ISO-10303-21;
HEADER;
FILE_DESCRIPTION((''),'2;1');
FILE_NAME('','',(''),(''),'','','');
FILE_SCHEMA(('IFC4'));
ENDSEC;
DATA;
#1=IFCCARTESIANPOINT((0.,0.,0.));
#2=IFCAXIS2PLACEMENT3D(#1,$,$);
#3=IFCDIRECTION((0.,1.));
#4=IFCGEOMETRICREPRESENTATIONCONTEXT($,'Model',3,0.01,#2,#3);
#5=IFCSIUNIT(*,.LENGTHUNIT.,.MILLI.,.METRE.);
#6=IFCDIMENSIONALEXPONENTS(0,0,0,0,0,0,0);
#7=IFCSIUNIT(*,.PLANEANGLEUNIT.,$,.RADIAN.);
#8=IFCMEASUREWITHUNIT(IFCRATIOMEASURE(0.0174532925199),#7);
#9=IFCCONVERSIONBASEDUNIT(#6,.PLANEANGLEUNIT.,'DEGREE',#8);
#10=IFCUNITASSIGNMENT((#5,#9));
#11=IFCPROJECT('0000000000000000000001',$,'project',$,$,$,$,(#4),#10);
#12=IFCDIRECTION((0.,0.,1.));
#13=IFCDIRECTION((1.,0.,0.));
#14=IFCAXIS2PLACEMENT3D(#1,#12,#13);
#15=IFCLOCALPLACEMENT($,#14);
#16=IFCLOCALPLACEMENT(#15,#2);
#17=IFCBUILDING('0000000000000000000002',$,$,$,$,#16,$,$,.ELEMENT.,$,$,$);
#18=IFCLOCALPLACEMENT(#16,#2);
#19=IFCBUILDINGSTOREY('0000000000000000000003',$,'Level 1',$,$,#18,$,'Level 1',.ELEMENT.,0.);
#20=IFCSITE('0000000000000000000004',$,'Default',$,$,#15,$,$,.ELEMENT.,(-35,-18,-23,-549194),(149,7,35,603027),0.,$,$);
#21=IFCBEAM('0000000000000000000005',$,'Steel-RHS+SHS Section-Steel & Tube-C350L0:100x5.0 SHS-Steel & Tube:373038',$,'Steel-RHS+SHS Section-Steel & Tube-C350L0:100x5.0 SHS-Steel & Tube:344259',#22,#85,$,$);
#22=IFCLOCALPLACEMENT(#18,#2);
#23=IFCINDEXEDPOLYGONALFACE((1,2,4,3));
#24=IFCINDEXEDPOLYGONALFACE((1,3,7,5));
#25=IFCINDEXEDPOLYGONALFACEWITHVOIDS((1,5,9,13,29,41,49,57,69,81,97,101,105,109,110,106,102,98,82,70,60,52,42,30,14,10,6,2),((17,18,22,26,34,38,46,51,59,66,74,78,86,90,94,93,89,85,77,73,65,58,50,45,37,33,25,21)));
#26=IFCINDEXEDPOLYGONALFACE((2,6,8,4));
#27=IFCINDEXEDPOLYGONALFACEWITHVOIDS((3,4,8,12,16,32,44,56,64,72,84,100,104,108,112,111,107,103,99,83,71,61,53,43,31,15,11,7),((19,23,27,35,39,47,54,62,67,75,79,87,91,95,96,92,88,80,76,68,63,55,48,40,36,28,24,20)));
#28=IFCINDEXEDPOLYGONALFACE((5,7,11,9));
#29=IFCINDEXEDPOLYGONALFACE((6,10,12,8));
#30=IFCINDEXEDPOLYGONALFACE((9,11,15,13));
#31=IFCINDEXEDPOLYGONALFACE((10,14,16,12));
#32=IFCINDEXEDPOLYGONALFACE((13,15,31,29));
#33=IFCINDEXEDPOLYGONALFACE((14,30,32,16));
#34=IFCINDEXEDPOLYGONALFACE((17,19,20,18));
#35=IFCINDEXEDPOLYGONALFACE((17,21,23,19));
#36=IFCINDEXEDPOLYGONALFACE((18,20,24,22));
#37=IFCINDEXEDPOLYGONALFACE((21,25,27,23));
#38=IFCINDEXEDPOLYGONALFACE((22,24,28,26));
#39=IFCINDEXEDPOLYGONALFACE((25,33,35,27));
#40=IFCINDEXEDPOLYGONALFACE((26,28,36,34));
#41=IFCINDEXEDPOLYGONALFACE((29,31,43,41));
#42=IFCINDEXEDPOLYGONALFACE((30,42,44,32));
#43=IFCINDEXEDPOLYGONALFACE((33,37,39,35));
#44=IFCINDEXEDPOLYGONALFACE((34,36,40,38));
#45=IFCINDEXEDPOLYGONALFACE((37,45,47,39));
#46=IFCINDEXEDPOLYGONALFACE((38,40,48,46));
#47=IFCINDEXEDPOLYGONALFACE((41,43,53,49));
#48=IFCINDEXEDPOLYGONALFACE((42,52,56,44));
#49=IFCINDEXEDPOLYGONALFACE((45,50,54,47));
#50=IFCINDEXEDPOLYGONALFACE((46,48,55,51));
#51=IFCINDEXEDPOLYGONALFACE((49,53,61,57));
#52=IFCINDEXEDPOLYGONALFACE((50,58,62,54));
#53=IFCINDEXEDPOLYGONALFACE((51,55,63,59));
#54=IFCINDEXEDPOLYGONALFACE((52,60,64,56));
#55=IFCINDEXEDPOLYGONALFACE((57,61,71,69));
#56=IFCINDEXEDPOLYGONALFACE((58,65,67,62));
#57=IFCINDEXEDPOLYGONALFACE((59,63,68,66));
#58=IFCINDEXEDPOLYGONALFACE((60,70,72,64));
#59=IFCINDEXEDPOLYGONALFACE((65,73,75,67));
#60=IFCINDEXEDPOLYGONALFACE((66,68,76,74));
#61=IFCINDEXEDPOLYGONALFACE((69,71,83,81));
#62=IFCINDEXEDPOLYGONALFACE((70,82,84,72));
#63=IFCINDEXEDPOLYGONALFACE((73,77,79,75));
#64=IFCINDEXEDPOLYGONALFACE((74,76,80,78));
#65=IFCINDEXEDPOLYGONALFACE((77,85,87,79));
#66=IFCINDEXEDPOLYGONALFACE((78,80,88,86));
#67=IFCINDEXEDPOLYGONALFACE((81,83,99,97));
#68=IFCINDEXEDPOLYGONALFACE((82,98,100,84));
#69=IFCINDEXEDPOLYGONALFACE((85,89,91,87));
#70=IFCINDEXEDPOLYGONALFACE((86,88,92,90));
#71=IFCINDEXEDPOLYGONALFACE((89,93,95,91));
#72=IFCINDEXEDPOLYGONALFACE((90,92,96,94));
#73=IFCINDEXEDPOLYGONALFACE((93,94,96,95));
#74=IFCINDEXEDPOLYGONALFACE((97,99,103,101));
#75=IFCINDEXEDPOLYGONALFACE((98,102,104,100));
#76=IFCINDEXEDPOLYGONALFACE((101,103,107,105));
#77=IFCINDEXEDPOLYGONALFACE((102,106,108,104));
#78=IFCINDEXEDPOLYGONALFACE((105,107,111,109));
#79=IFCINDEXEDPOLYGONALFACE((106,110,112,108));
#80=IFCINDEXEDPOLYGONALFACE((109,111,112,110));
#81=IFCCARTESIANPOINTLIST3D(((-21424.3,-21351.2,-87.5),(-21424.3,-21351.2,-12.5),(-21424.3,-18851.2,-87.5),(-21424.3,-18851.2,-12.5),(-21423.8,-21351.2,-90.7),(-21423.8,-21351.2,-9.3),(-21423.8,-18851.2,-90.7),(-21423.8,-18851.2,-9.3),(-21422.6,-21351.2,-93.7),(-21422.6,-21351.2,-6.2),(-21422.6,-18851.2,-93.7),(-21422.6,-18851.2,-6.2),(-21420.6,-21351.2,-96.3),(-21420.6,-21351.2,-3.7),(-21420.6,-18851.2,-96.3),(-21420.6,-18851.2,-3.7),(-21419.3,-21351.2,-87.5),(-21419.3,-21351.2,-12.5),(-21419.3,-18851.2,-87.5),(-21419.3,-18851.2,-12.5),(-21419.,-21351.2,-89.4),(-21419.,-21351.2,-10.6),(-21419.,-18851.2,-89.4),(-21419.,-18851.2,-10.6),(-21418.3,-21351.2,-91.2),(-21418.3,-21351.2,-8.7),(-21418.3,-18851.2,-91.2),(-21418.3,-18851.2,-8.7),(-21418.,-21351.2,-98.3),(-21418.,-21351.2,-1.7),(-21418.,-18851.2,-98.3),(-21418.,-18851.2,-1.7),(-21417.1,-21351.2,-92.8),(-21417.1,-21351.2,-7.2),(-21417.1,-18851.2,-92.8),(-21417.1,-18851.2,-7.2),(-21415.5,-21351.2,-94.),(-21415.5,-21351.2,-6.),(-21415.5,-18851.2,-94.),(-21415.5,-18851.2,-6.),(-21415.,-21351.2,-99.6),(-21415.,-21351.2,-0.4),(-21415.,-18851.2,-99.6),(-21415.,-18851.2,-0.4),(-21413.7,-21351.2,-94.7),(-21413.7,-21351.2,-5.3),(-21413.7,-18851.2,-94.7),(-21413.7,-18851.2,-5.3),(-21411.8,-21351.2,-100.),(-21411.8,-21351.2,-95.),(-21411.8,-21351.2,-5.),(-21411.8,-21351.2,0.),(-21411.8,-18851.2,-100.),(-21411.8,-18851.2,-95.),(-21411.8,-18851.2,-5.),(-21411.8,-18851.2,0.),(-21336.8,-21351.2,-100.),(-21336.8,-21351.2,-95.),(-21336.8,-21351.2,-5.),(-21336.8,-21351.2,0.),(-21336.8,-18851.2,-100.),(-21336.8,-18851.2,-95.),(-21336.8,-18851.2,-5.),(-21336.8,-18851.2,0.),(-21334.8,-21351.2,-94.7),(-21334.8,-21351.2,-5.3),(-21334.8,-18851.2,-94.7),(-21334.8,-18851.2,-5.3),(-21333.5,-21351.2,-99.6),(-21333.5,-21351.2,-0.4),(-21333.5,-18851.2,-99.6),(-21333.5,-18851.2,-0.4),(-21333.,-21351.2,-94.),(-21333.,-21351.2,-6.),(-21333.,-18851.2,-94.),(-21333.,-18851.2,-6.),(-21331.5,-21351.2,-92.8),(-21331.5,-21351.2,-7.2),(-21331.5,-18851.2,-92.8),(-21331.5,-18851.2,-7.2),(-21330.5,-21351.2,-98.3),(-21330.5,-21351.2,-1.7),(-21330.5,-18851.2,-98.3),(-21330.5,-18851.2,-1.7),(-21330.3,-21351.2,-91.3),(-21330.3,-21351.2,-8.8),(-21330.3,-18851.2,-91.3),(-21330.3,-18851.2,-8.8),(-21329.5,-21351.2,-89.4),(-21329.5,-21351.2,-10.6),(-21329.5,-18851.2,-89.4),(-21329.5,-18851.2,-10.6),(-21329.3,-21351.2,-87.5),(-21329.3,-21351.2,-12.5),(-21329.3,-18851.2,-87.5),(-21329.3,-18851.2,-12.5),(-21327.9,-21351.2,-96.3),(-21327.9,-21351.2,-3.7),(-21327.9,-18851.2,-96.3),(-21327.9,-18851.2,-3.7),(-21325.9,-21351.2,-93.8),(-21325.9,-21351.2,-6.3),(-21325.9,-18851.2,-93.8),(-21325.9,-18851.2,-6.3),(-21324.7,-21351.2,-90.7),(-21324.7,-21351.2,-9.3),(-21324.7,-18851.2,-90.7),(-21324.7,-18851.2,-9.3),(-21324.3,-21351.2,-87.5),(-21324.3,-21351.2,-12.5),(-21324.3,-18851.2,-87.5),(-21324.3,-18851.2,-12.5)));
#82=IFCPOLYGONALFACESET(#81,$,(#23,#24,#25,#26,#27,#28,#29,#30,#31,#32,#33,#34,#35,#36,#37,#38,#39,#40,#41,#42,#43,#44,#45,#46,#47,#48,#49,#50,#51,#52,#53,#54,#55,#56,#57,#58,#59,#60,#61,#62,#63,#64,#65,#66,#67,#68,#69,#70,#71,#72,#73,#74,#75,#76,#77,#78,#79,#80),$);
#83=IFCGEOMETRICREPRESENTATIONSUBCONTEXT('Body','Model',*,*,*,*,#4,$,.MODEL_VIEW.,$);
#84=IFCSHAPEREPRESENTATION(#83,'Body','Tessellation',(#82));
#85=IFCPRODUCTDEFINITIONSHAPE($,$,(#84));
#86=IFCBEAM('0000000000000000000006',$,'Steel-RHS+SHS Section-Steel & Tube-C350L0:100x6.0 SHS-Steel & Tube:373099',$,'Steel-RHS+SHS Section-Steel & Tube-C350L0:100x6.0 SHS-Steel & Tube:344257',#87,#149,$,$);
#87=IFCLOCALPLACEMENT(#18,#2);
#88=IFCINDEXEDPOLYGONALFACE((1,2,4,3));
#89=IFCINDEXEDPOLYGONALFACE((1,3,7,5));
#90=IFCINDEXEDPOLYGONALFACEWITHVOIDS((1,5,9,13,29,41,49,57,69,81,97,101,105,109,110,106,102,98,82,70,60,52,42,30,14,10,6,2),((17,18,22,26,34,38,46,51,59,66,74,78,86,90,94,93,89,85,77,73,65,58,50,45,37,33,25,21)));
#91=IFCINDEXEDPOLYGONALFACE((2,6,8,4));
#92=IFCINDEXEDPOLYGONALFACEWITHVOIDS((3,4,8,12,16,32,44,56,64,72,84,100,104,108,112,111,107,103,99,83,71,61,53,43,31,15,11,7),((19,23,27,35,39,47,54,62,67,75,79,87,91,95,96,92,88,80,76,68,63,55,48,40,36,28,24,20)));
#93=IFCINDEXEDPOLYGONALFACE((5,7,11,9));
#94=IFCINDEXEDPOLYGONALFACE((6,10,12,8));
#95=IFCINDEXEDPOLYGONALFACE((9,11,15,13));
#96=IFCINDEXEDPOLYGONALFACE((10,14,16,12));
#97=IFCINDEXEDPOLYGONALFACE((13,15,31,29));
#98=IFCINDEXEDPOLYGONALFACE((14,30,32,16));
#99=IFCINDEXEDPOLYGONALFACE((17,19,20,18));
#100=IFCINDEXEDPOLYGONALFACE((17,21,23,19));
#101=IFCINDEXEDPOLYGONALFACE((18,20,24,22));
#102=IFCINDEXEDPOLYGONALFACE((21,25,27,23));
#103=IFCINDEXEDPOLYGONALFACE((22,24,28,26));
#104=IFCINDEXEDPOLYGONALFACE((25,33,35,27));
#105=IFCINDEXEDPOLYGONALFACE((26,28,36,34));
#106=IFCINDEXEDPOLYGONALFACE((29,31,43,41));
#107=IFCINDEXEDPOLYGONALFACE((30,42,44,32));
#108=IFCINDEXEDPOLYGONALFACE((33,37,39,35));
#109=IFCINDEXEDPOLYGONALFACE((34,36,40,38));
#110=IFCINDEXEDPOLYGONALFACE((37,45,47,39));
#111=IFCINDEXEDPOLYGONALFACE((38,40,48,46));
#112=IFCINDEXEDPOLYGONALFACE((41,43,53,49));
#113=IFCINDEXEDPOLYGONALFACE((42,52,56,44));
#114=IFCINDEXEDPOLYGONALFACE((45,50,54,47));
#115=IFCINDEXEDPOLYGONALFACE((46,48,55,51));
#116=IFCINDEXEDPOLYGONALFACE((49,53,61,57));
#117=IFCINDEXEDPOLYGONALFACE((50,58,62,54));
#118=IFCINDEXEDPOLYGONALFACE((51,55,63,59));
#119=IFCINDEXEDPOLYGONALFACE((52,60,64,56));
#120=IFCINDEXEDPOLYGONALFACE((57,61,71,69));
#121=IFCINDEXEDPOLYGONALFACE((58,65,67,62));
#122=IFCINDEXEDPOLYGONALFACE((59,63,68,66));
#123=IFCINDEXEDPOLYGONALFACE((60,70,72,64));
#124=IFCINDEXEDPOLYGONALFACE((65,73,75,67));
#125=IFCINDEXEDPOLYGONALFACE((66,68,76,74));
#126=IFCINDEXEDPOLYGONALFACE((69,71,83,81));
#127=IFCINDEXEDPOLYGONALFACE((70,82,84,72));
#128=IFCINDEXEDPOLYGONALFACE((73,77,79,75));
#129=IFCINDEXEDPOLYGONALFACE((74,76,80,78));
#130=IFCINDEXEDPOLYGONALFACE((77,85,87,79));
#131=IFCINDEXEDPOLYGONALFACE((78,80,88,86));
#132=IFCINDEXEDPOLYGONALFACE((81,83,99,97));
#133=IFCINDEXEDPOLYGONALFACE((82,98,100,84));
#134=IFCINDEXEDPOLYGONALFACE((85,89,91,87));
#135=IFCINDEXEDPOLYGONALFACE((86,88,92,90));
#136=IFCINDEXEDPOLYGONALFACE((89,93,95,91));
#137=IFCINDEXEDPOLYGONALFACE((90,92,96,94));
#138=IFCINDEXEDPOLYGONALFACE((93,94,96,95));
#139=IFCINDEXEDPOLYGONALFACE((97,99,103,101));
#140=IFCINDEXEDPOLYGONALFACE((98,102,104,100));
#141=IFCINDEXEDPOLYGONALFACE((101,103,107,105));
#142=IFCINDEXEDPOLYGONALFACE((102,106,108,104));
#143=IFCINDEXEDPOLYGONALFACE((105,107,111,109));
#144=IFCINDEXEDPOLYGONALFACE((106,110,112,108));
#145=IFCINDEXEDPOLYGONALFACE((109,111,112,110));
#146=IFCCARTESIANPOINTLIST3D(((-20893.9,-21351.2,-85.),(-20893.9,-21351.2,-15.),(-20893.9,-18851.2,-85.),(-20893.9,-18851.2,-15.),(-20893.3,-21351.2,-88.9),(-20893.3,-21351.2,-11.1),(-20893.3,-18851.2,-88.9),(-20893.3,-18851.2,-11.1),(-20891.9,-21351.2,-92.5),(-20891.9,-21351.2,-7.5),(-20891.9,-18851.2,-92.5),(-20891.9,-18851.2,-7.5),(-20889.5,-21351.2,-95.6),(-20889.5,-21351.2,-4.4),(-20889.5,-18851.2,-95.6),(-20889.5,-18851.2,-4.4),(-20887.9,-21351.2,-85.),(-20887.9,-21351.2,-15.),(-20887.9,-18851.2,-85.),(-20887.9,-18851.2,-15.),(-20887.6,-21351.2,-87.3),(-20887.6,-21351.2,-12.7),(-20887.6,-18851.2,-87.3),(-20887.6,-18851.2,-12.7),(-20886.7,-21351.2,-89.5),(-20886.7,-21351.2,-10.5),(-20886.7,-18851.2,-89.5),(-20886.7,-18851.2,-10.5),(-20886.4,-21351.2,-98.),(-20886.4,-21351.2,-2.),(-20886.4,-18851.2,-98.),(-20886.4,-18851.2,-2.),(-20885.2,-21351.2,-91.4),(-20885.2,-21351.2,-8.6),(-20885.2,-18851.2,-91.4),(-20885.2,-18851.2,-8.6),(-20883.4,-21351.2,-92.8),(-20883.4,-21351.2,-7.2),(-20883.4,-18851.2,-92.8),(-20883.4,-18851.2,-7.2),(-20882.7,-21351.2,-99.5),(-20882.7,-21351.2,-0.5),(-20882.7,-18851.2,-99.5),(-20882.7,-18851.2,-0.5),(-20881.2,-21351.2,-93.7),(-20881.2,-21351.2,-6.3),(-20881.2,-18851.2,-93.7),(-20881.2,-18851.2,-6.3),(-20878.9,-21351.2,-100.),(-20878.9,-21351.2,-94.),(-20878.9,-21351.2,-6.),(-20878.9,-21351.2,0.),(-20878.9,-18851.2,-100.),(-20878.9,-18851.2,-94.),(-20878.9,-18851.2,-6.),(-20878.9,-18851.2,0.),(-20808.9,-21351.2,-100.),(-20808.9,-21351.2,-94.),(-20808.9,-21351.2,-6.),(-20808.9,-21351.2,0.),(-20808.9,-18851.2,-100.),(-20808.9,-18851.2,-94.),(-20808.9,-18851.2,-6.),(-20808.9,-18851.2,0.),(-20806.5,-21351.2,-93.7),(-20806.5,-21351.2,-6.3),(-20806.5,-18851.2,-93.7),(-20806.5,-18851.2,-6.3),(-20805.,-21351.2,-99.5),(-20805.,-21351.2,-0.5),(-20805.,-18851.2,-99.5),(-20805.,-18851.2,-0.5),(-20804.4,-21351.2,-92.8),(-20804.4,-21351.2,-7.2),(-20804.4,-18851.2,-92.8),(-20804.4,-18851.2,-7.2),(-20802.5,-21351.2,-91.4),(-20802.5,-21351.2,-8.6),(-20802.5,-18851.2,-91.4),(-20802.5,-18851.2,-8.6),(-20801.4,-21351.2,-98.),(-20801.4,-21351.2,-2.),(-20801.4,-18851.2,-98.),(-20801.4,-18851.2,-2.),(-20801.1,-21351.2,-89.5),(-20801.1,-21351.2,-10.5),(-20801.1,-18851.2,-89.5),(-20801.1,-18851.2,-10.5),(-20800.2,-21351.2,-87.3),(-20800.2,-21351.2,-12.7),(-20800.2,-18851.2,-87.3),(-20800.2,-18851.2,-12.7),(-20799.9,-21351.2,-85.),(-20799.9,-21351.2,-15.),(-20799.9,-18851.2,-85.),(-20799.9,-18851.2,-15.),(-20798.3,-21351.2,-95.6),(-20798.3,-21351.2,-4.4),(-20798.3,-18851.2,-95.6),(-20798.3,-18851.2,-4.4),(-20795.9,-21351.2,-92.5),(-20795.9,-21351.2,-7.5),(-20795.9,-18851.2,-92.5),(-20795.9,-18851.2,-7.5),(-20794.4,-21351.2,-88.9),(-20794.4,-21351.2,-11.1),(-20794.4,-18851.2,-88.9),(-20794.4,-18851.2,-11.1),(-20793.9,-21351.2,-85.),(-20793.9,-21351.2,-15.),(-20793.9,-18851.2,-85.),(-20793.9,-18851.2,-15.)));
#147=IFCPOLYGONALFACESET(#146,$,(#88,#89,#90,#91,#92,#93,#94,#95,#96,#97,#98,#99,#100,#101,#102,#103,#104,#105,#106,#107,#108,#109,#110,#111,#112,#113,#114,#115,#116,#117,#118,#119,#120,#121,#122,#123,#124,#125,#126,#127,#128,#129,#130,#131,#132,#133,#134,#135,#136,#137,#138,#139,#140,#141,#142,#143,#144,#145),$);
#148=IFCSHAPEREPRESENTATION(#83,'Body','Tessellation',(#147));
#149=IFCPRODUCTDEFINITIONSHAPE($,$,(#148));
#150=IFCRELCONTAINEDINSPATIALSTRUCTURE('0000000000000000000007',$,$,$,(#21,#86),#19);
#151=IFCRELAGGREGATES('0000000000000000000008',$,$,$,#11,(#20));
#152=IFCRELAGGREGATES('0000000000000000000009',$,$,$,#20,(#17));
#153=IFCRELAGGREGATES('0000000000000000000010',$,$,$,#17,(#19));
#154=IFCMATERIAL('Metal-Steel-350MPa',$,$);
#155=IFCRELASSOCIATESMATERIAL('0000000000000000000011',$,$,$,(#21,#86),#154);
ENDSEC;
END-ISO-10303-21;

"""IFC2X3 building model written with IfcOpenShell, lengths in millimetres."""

from ifc_helpers import new_model, entity, si_unit, converted_unit, direction, frame, frame_2d, origin, origin_with_axes, place, context, subcontext, project, spatial, polyline, circle_curve, parameter, trimmed, segment, composite_curve, outline, extrude, material, element, save


model = new_model("IFC2X3")

# Units and contexts
model_context = context("Model", 3, precision=0.01, world=origin(), true_north=direction((0.0, 1.0)))
body_context = subcontext(model_context, "Body", "Model", "MODEL_VIEW")
ifc_project = project(units=[si_unit("LENGTHUNIT", "METRE", prefix="MILLI"), converted_unit("PLANEANGLEUNIT", "DEGREE", entity("IfcRatioMeasure", 0.0174532925199), si_unit("PLANEANGLEUNIT", "RADIAN"), dimensions=[0, 0, 0, 0, 0, 0, 0])], contexts=[model_context])

# Site, building, storey
site_placement = place(None, origin_with_axes())
site = spatial("IfcSite", under=ifc_project, at=site_placement, Name="Default", CompositionType="ELEMENT", RefLatitude=(-35, -18, -23, -549194), RefLongitude=(149, 7, 35, 603027), RefElevation=0.0)
building_placement = place(site_placement, origin())
building = spatial("IfcBuilding", under=site, at=building_placement, CompositionType="ELEMENT")
storey_placement = place(building_placement, origin())
storey = spatial("IfcBuildingStorey", under=building, at=storey_placement, Name="Level 1", LongName="Level 1", CompositionType="ELEMENT", Elevation=0.0)

# Beams
ifc_material = material(Name="Metal-Steel-350MPa")
beam_1_placement = place(storey_placement, frame((-21374.3, -18851.2, 0.0), z_axis=(0.0, 0.0, 1.0), x_axis=(0.0, -1.0, 0.0)))
element("IfcBeam", 1, at=beam_1_placement, inside=storey, material=ifc_material, Name="Steel-RHS+SHS Section-Steel & Tube-C350L0:100x5.0 SHS-Steel & Tube:373038", ObjectType="Steel-RHS+SHS Section-Steel & Tube-C350L0:100x5.0 SHS-Steel & Tube:344259", context=body_context, shape_type="SweptSolid", body=[
    extrude(outline(composite_curve([segment(trimmed(circle_curve(frame_2d((-37.5, -37.5), x_axis=(1.0, 0.0)), 12.5), [parameter(180.0)], [parameter(270.0)], True, "PARAMETER"), True, "CONTINUOUS"), segment(polyline([(-37.5, -50.0), (37.5, -50.0)]), True, "CONTINUOUS"), segment(trimmed(circle_curve(frame_2d((37.5, -37.5), x_axis=(1.0, 0.0)), 12.5), [parameter(270.0)], [parameter(0.0)], True, "PARAMETER"), True, "CONTINUOUS"), segment(polyline([(50.0, -37.5), (50.0, 37.5)]), True, "CONTINUOUS"), segment(trimmed(circle_curve(frame_2d((37.5, 37.5), x_axis=(1.0, 0.0)), 12.5), [parameter(0.0)], [parameter(90.0)], True, "PARAMETER"), True, "CONTINUOUS"), segment(polyline([(37.5, 50.0), (-37.5, 50.0)]), True, "CONTINUOUS"), segment(trimmed(circle_curve(frame_2d((-37.5, 37.5), x_axis=(1.0, 0.0)), 12.5), [parameter(90.0)], [parameter(180.0)], True, "PARAMETER"), True, "CONTINUOUS"), segment(polyline([(-50.0, 37.5), (-50.0, -37.5)]), True, "CONTINUOUS")], self_intersect=False), holes=[composite_curve([segment(polyline([(37.5, -45.0), (-37.5, -45.0)]), True, "CONTINUOUS"), segment(trimmed(circle_curve(frame_2d((-37.5, -37.5), x_axis=(1.0, 0.0)), 7.5), [parameter(180.0)], [parameter(270.0)], True, "PARAMETER"), False, "CONTINUOUS"), segment(polyline([(-45.0, -37.5), (-45.0, 37.5)]), True, "CONTINUOUS"), segment(trimmed(circle_curve(frame_2d((-37.5, 37.5), x_axis=(1.0, 0.0)), 7.5), [parameter(90.0)], [parameter(180.0)], True, "PARAMETER"), False, "CONTINUOUS"), segment(polyline([(-37.5, 45.0), (37.5, 45.0)]), True, "CONTINUOUS"), segment(trimmed(circle_curve(frame_2d((37.5, 37.5), x_axis=(1.0, 0.0)), 7.5), [parameter(360.0)], [parameter(90.0)], True, "PARAMETER"), False, "CONTINUOUS"), segment(polyline([(45.0, 37.5), (45.0, -37.5)]), True, "CONTINUOUS"), segment(trimmed(circle_curve(frame_2d((37.5, -37.5), x_axis=(1.0, 0.0)), 7.5), [parameter(270.0)], [parameter(360.0)], True, "PARAMETER"), False, "CONTINUOUS")], self_intersect=False)]), frame((0.0, 0.0, -50.0), z_axis=(1.0, 0.0, 0.0), x_axis=(0.0, -1.0, 0.0)), (0.0, 0.0, 1.0), 2500.0),
])
beam_2_placement = place(storey_placement, frame((-20843.9, -18851.2, 0.0), z_axis=(0.0, 0.0, 1.0), x_axis=(0.0, -1.0, 0.0)))
element("IfcBeam", 2, at=beam_2_placement, inside=storey, material=ifc_material, Name="Steel-RHS+SHS Section-Steel & Tube-C350L0:100x6.0 SHS-Steel & Tube:373099", ObjectType="Steel-RHS+SHS Section-Steel & Tube-C350L0:100x6.0 SHS-Steel & Tube:344257", context=body_context, shape_type="SweptSolid", body=[
    extrude(outline(composite_curve([segment(trimmed(circle_curve(frame_2d((-35.0, -35.0), x_axis=(1.0, 0.0)), 15.0), [parameter(180.0)], [parameter(270.0)], True, "PARAMETER"), True, "CONTINUOUS"), segment(polyline([(-35.0, -50.0), (35.0, -50.0)]), True, "CONTINUOUS"), segment(trimmed(circle_curve(frame_2d((35.0, -35.0), x_axis=(1.0, 0.0)), 15.0), [parameter(270.0)], [parameter(0.0)], True, "PARAMETER"), True, "CONTINUOUS"), segment(polyline([(50.0, -35.0), (50.0, 35.0)]), True, "CONTINUOUS"), segment(trimmed(circle_curve(frame_2d((35.0, 35.0), x_axis=(1.0, 0.0)), 15.0), [parameter(0.0)], [parameter(90.0)], True, "PARAMETER"), True, "CONTINUOUS"), segment(polyline([(35.0, 50.0), (-35.0, 50.0)]), True, "CONTINUOUS"), segment(trimmed(circle_curve(frame_2d((-35.0, 35.0), x_axis=(1.0, 0.0)), 15.0), [parameter(90.0)], [parameter(180.0)], True, "PARAMETER"), True, "CONTINUOUS"), segment(polyline([(-50.0, 35.0), (-50.0, -35.0)]), True, "CONTINUOUS")], self_intersect=False), holes=[composite_curve([segment(polyline([(35.0, -44.0), (-35.0, -44.0)]), True, "CONTINUOUS"), segment(trimmed(circle_curve(frame_2d((-35.0, -35.0), x_axis=(1.0, 0.0)), 9.0), [parameter(180.0)], [parameter(270.0)], True, "PARAMETER"), False, "CONTINUOUS"), segment(polyline([(-44.0, -35.0), (-44.0, 35.0)]), True, "CONTINUOUS"), segment(trimmed(circle_curve(frame_2d((-35.0, 35.0), x_axis=(1.0, 0.0)), 9.0), [parameter(90.0)], [parameter(180.0)], True, "PARAMETER"), False, "CONTINUOUS"), segment(polyline([(-35.0, 44.0), (35.0, 44.0)]), True, "CONTINUOUS"), segment(trimmed(circle_curve(frame_2d((35.0, 35.0), x_axis=(1.0, 0.0)), 9.0), [parameter(360.0)], [parameter(90.0)], True, "PARAMETER"), False, "CONTINUOUS"), segment(polyline([(44.0, 35.0), (44.0, -35.0)]), True, "CONTINUOUS"), segment(trimmed(circle_curve(frame_2d((35.0, -35.0), x_axis=(1.0, 0.0)), 9.0), [parameter(270.0)], [parameter(0.0)], True, "PARAMETER"), False, "CONTINUOUS")], self_intersect=False)]), frame((0.0, 0.0, -50.0), z_axis=(1.0, 0.0, 0.0), x_axis=(0.0, -1.0, 0.0)), (0.0, 0.0, 1.0), 2500.0),
])

save(model, "model.ifc")
